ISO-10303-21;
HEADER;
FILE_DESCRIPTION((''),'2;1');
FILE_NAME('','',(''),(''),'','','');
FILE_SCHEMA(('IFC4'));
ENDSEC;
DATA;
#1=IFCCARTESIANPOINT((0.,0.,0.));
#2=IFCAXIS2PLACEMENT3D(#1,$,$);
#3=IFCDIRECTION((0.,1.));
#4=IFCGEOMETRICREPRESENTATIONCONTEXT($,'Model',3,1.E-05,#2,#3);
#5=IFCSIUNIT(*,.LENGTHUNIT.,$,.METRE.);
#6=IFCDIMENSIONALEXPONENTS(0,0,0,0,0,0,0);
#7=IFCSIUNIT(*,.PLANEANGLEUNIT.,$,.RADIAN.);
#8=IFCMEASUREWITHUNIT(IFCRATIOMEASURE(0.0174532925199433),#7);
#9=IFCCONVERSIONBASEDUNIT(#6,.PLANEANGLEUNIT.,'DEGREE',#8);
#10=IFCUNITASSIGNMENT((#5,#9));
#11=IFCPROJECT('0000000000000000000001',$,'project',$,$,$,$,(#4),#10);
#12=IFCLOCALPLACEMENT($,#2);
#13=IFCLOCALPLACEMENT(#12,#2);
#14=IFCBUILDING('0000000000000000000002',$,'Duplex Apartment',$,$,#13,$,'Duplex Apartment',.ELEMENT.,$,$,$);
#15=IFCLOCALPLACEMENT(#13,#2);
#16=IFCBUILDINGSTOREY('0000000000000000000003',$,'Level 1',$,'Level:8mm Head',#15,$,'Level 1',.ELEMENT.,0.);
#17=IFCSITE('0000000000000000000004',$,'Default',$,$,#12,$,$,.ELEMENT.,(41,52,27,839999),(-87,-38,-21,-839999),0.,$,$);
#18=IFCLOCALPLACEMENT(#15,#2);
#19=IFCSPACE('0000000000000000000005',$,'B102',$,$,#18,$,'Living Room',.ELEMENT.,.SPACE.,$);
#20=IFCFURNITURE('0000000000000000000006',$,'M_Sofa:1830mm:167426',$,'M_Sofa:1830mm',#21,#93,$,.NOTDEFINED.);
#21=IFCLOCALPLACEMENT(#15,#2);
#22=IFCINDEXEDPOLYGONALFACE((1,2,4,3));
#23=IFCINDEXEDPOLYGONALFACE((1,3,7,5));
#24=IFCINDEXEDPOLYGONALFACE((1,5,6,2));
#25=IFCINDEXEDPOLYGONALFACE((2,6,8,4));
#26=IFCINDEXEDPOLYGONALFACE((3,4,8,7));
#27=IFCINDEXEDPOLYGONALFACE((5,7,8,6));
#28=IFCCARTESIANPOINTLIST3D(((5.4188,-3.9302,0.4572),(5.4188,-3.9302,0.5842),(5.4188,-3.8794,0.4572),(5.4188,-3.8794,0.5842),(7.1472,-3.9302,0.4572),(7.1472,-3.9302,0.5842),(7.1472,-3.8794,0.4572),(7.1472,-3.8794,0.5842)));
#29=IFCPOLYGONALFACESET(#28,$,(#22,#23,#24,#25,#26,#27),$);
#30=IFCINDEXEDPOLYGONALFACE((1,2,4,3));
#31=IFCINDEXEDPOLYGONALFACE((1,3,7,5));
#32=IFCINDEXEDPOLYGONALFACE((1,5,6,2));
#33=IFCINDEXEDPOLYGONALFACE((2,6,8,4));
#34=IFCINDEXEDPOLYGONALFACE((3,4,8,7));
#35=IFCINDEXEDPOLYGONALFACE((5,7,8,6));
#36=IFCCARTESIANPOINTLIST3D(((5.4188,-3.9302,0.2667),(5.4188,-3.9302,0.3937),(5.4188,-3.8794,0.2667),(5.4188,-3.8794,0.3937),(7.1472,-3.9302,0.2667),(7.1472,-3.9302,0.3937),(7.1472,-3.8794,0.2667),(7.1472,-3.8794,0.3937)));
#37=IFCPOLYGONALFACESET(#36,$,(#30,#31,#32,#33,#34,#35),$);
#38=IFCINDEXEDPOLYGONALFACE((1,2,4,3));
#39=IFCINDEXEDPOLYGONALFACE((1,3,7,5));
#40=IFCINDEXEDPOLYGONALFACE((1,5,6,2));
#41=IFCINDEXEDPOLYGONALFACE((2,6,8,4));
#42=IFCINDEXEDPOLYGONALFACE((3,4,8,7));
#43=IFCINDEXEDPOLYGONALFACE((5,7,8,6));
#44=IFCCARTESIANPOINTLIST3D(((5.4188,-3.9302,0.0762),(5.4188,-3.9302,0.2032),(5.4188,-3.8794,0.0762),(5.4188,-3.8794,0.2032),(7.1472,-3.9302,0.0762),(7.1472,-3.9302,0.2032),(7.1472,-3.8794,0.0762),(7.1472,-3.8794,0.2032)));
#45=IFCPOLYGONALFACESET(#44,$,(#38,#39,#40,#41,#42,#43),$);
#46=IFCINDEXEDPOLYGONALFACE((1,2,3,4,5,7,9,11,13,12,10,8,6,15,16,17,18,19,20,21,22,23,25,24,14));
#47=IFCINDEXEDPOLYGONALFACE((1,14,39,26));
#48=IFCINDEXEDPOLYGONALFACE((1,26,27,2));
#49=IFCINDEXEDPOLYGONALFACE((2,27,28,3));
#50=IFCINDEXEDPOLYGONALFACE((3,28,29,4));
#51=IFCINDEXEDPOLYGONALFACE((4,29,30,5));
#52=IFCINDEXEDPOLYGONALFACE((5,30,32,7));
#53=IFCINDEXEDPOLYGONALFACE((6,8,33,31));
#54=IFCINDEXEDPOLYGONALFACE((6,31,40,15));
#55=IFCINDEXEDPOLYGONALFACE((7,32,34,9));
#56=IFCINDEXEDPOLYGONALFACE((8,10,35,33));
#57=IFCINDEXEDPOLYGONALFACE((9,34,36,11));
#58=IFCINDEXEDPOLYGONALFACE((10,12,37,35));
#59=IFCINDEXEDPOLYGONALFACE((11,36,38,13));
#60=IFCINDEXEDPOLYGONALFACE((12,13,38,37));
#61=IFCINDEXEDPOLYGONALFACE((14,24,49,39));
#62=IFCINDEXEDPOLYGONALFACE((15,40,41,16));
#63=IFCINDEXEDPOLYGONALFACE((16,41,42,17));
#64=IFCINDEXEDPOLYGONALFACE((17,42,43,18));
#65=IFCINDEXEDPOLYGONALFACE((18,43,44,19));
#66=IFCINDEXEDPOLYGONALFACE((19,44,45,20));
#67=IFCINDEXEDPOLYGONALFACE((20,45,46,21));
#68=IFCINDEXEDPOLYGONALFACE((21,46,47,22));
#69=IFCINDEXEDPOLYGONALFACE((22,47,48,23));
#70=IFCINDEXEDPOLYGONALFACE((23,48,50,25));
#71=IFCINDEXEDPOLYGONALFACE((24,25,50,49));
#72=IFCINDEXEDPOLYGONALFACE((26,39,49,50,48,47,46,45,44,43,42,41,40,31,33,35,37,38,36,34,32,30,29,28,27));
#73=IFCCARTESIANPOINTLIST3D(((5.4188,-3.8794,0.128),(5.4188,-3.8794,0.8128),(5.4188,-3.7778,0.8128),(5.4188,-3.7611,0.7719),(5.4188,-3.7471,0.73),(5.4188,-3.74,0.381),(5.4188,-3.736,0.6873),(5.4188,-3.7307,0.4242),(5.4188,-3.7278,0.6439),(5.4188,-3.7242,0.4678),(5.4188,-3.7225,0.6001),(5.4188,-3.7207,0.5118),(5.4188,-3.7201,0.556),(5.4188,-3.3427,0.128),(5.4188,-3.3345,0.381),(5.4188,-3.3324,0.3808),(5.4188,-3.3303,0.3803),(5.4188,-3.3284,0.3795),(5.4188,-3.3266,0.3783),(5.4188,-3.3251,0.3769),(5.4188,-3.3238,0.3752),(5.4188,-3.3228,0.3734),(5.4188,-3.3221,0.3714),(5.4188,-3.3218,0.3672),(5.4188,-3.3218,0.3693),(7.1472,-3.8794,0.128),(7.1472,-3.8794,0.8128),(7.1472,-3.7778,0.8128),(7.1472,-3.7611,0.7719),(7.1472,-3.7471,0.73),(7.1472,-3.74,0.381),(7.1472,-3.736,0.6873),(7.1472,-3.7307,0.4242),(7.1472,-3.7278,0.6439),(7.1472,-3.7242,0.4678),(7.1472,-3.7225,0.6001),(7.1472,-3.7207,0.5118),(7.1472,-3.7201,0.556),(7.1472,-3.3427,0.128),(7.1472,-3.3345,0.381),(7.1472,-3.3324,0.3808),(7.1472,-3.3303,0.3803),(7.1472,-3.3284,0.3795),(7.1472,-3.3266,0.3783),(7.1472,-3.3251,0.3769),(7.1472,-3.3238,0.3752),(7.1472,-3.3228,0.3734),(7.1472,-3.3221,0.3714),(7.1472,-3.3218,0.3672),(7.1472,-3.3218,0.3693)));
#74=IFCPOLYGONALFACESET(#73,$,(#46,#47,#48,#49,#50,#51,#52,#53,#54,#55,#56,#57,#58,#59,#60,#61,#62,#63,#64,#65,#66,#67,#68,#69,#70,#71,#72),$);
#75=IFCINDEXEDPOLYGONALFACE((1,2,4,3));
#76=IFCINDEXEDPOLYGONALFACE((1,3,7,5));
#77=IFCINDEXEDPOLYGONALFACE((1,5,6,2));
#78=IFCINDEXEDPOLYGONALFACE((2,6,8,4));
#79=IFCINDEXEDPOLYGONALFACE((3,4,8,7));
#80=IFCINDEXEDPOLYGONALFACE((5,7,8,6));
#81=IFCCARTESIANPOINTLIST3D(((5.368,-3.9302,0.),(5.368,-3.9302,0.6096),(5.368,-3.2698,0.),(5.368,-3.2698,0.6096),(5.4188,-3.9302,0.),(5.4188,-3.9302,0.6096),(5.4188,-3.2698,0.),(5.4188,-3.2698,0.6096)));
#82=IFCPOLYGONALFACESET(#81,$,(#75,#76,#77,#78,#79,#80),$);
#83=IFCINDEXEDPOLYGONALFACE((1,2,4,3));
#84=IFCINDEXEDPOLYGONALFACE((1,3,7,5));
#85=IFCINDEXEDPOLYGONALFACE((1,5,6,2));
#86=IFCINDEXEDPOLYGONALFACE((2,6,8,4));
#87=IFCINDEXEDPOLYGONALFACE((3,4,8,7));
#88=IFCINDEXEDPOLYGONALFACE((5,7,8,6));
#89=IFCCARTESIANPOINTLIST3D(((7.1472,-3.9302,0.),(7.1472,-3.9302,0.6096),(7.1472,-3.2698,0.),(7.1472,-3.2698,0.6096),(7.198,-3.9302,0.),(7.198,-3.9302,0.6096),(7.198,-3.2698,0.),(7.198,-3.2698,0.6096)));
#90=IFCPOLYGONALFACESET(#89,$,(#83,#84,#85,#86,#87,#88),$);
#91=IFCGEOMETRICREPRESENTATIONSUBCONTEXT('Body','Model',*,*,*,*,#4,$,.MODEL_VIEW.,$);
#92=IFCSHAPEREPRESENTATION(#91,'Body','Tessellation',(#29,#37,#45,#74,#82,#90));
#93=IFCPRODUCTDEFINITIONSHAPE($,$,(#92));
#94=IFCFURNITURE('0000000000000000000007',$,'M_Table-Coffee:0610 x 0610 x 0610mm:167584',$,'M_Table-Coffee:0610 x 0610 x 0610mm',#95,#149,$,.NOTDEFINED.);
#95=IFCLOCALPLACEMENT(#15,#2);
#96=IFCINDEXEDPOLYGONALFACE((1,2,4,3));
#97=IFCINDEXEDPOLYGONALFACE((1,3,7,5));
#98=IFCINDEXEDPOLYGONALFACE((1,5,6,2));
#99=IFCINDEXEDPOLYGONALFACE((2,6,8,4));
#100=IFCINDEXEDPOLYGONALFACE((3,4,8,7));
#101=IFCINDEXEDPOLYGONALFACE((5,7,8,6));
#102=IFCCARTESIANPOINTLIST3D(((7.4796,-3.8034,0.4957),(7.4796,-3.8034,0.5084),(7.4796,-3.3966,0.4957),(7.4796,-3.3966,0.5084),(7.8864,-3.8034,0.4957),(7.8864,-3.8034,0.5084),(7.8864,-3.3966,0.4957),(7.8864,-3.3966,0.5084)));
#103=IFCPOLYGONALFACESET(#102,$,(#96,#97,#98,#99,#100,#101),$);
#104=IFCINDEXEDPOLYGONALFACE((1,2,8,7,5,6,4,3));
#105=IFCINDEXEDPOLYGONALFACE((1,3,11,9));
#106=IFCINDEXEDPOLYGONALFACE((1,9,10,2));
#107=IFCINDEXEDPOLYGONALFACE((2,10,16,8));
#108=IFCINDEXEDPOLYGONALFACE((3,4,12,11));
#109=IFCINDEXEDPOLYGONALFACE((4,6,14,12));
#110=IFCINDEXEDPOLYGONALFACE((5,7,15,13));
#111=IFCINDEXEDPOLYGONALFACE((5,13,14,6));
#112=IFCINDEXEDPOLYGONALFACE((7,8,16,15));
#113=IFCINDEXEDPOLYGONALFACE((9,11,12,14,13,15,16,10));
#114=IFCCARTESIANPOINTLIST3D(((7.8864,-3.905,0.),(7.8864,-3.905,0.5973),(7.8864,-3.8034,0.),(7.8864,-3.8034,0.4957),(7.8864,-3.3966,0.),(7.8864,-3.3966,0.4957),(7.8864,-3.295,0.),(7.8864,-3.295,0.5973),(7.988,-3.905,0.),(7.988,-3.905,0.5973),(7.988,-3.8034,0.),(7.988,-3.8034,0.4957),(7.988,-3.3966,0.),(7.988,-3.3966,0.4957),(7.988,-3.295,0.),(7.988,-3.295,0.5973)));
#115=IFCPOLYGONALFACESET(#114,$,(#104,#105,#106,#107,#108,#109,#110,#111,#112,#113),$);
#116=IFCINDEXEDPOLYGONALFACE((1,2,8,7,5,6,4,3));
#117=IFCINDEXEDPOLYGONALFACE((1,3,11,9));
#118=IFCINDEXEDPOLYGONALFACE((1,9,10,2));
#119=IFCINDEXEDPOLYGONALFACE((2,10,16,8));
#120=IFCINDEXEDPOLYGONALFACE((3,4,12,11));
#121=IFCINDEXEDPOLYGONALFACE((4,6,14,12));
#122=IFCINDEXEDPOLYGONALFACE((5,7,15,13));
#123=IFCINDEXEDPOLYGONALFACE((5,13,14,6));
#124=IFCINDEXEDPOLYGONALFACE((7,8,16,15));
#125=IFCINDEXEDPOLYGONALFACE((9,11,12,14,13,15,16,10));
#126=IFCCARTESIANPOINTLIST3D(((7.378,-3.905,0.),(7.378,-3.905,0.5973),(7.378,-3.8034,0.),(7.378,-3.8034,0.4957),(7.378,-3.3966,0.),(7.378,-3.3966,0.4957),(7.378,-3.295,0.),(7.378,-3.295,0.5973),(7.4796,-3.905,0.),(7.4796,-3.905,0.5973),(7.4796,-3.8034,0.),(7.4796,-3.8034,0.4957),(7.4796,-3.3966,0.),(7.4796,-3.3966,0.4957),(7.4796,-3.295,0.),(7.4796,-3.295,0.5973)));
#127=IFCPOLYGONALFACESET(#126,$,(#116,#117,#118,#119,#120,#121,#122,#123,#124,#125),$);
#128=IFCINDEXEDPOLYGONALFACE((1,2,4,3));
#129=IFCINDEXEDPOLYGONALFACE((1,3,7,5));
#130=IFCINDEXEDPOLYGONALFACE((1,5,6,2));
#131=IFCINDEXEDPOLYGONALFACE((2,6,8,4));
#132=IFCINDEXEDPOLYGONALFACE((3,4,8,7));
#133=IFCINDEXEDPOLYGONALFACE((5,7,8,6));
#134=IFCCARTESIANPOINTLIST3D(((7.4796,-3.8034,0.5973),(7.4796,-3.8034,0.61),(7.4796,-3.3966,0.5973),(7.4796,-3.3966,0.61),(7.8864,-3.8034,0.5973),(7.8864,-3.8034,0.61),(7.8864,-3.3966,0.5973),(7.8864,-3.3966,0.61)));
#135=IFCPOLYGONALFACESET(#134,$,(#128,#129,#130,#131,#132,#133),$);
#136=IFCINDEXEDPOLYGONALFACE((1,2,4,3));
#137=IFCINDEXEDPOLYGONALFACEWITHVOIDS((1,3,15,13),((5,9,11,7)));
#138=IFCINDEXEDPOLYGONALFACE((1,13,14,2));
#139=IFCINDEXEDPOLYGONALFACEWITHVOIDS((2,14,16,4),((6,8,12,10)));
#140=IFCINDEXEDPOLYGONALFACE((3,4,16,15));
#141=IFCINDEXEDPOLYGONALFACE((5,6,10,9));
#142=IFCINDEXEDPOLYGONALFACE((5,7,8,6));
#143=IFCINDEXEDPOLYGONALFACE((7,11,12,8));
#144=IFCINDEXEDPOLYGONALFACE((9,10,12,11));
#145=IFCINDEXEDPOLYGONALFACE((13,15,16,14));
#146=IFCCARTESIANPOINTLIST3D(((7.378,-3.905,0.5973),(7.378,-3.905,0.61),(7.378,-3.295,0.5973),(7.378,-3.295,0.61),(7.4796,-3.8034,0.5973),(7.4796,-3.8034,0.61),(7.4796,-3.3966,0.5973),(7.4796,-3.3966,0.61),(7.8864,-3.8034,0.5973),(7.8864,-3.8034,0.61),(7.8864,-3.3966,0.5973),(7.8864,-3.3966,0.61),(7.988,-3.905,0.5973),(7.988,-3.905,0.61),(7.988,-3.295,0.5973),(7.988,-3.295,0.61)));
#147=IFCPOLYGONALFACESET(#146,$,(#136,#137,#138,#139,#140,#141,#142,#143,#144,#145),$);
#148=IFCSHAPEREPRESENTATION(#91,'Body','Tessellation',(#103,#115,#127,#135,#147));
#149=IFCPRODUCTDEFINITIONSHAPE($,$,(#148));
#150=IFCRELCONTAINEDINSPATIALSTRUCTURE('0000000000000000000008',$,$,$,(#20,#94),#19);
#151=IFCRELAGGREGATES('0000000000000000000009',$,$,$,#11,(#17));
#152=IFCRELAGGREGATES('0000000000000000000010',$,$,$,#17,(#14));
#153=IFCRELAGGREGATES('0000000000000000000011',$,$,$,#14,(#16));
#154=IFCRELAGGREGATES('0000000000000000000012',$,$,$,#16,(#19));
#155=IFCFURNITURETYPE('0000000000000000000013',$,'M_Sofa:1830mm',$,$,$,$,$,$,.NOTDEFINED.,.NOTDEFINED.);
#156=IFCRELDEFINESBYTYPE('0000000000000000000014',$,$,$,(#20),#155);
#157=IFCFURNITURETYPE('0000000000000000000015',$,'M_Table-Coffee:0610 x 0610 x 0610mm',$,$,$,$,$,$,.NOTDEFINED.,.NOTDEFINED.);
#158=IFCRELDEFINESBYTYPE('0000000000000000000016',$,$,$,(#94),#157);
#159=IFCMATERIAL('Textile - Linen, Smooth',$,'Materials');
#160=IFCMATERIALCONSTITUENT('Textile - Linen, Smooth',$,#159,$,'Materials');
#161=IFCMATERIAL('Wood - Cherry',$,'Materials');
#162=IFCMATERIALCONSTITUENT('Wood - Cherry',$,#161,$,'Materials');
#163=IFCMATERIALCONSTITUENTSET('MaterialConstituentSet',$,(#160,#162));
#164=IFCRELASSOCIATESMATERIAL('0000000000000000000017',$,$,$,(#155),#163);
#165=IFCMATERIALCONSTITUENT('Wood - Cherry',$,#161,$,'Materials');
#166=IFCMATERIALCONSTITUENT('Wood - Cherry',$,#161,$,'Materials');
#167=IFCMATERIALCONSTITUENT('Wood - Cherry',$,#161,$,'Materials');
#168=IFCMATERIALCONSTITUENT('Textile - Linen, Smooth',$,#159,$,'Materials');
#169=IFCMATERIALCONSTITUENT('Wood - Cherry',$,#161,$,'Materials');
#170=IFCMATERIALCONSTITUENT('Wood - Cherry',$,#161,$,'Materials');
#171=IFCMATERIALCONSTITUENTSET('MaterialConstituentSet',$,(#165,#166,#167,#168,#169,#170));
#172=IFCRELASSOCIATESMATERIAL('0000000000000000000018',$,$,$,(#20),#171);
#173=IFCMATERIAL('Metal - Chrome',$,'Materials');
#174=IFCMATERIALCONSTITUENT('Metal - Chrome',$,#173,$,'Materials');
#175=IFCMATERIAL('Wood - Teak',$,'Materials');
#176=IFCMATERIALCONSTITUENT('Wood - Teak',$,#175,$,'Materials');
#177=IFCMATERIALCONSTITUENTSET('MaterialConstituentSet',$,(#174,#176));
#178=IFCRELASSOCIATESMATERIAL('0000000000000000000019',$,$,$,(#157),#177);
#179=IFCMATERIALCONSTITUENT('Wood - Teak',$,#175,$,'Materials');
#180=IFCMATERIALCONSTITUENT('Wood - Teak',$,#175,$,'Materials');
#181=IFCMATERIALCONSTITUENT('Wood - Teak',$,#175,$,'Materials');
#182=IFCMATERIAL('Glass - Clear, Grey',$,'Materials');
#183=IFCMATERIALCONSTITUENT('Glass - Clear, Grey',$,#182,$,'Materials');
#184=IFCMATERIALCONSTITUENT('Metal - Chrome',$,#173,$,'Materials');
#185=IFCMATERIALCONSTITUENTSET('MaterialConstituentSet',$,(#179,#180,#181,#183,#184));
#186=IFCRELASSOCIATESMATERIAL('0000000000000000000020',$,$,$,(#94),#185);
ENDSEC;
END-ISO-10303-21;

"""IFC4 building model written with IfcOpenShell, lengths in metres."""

from ifc_helpers import new_model, entity, si_unit, converted_unit, direction, frame, origin, place, context, subcontext, project, spatial, indexed_curve, outline, extrude, source, transform, mapped, material, constituent, constituent_set, type_object, type_shapes, element, save


model = new_model("IFC4")

# Units and contexts
model_context = context("Model", 3, precision=1e-05, world=origin(), true_north=direction((0.0, 1.0)))
body_context = subcontext(model_context, "Body", "Model", "MODEL_VIEW")
ifc_project = project(units=[si_unit("LENGTHUNIT", "METRE"), converted_unit("PLANEANGLEUNIT", "DEGREE", entity("IfcRatioMeasure", 0.0174532925199433), si_unit("PLANEANGLEUNIT", "RADIAN"), dimensions=[0, 0, 0, 0, 0, 0, 0])], contexts=[model_context])

# Site, building, storey
site_placement = place(None, origin())
site = spatial("IfcSite", under=ifc_project, at=site_placement, Name="Default", CompositionType="ELEMENT", RefLatitude=(41, 52, 27, 839999), RefLongitude=(-87, -38, -21, -839999), RefElevation=0.0)
building_placement = place(site_placement, origin())
building = spatial("IfcBuilding", under=site, at=building_placement, Name="Duplex Apartment", LongName="Duplex Apartment", CompositionType="ELEMENT")
storey_placement = place(building_placement, origin())
storey = spatial("IfcBuildingStorey", under=building, at=storey_placement, Name="Level 1", ObjectType="Level:8mm Head", LongName="Level 1", CompositionType="ELEMENT", Elevation=0.0)

# Shared definitions
space_1_placement = place(storey_placement, origin())
space_1 = spatial("IfcSpace", under=storey, at=space_1_placement, Name="B102", LongName="Living Room", CompositionType="ELEMENT", PredefinedType="SPACE")

# Furniture
ifc_material_1 = material(Name="Wood - Cherry", Category="Materials")
ifc_constituent_1 = constituent(ifc_material_1, Name="Wood - Cherry", Category="Materials")
ifc_constituent_2 = constituent(ifc_material_1, Name="Wood - Cherry", Category="Materials")
ifc_constituent_3 = constituent(ifc_material_1, Name="Wood - Cherry", Category="Materials")
ifc_material_2 = material(Name="Textile - Linen, Smooth", Category="Materials")
ifc_constituent_4 = constituent(ifc_material_2, Name="Textile - Linen, Smooth", Category="Materials")
ifc_constituent_5 = constituent(ifc_material_1, Name="Wood - Cherry", Category="Materials")
ifc_constituent_6 = constituent(ifc_material_1, Name="Wood - Cherry", Category="Materials")
ifc_constituent_set_1 = constituent_set(constituents=[ifc_constituent_1, ifc_constituent_2, ifc_constituent_3, ifc_constituent_4, ifc_constituent_5, ifc_constituent_6], Name="MaterialConstituentSet")
ifc_constituent_7 = constituent(ifc_material_2, Name="Textile - Linen, Smooth", Category="Materials")
ifc_constituent_8 = constituent(ifc_material_1, Name="Wood - Cherry", Category="Materials")
ifc_constituent_set_2 = constituent_set(constituents=[ifc_constituent_7, ifc_constituent_8], Name="MaterialConstituentSet")
furniture_type_1 = type_object("IfcFurnitureType", Name="M_Sofa:1830mm", AssemblyPlace="NOTDEFINED", PredefinedType="NOTDEFINED", material=ifc_constituent_set_2)
shared_shape_1 = source(origin(), body_context, "Body", "SweptSolid", [
    extrude(outline(indexed_curve([(-0.8642, -0.0254), (0.8642, -0.0254), (0.8642, 0.0254), (-0.8642, 0.0254), (-0.8642, -0.0254)], self_intersect=False)), frame((0.0704, 0.451, 0.4572)), (0.0, 0.0, 1.0), 0.127),
    extrude(outline(indexed_curve([(-0.8642, -0.0254), (0.8642, -0.0254), (0.8642, 0.0254), (-0.8642, 0.0254), (-0.8642, -0.0254)], self_intersect=False)), frame((0.0704, 0.451, 0.2667)), (0.0, 0.0, 1.0), 0.127),
    extrude(outline(indexed_curve([(-0.8642, -0.0254), (0.8642, -0.0254), (0.8642, 0.0254), (-0.8642, 0.0254), (-0.8642, -0.0254)], self_intersect=False)), frame((0.0704, 0.451, 0.0762)), (0.0, 0.0, 1.0), 0.127),
    extrude(outline(indexed_curve([(-0.1292, 0.0491), (0.2763, 0.0491), (0.2784, 0.0493), (0.2805, 0.0498), (0.2824, 0.0506), (0.2842, 0.0518), (0.2857, 0.0532), (0.287, 0.0549), (0.288, 0.0567), (0.2887, 0.0587), (0.289, 0.0608), (0.289, 0.0629), (0.2681, 0.3021), (-0.2686, 0.3021), (-0.2686, -0.3827), (-0.167, -0.3827), (-0.1503, -0.3418), (-0.1363, -0.2999), (-0.1252, -0.2572), (-0.117, -0.2138), (-0.1117, -0.17), (-0.1093, -0.1259), (-0.1099, -0.0817), (-0.1134, -0.0377), (-0.1199, 0.006), (-0.1292, 0.0491)], self_intersect=False)), frame((-0.7938, 0.157, 0.4301), z_axis=(1.0, 0.0, 0.0), x_axis=(0.0, -1.0, 0.0)), (0.0, 0.0, 1.0), 1.7284),
    extrude(outline(indexed_curve([(-0.0254, -0.3302), (0.0254, -0.3302), (0.0254, 0.3302), (-0.0254, 0.3302), (-0.0254, -0.3302)], self_intersect=False)), frame((0.96, 0.1462, 0.0), z_axis=(0.0, 0.0, 1.0), x_axis=(-1.0, 0.0, 0.0)), (0.0, 0.0, 1.0), 0.6096),
    extrude(outline(indexed_curve([(-0.0254, -0.3302), (0.0254, -0.3302), (0.0254, 0.3302), (-0.0254, 0.3302), (-0.0254, -0.3302)], self_intersect=False)), frame((-0.8192, 0.1462, 0.0), z_axis=(0.0, 0.0, 1.0), x_axis=(-1.0, 0.0, 0.0)), (0.0, 0.0, 1.0), 0.6096),
])
type_shapes(furniture_type_1, [shared_shape_1])
furniture_1_placement = place(space_1_placement, frame((6.3534, -3.4538, 0.0), z_axis=(0.0, 0.0, 1.0), x_axis=(-1.0, 0.0, 0.0)))
element("IfcFurniture", 1, at=furniture_1_placement, inside=space_1, type_object=furniture_type_1, material=ifc_constituent_set_1, Name="M_Sofa:1830mm:167426", ObjectType="M_Sofa:1830mm", PredefinedType="NOTDEFINED", context=body_context, shape_type="MappedRepresentation", body=[
    mapped(shared_shape_1, transform((0.0, 0.0, 0.0), scale=1.0)),
])
ifc_material_3 = material(Name="Wood - Teak", Category="Materials")
ifc_constituent_9 = constituent(ifc_material_3, Name="Wood - Teak", Category="Materials")
ifc_constituent_10 = constituent(ifc_material_3, Name="Wood - Teak", Category="Materials")
ifc_constituent_11 = constituent(ifc_material_3, Name="Wood - Teak", Category="Materials")
ifc_material_4 = material(Name="Glass - Clear, Grey", Category="Materials")
ifc_constituent_12 = constituent(ifc_material_4, Name="Glass - Clear, Grey", Category="Materials")
ifc_material_5 = material(Name="Metal - Chrome", Category="Materials")
ifc_constituent_13 = constituent(ifc_material_5, Name="Metal - Chrome", Category="Materials")
ifc_constituent_set_3 = constituent_set(constituents=[ifc_constituent_9, ifc_constituent_10, ifc_constituent_11, ifc_constituent_12, ifc_constituent_13], Name="MaterialConstituentSet")
ifc_constituent_14 = constituent(ifc_material_5, Name="Metal - Chrome", Category="Materials")
ifc_constituent_15 = constituent(ifc_material_3, Name="Wood - Teak", Category="Materials")
ifc_constituent_set_4 = constituent_set(constituents=[ifc_constituent_14, ifc_constituent_15], Name="MaterialConstituentSet")
furniture_type_2 = type_object("IfcFurnitureType", Name="M_Table-Coffee:0610 x 0610 x 0610mm", AssemblyPlace="NOTDEFINED", PredefinedType="NOTDEFINED", material=ifc_constituent_set_4)
shared_shape_2 = source(origin(), body_context, "Body", "SweptSolid", [
    extrude(outline(indexed_curve([(-0.2034, -0.2034), (0.2034, -0.2034), (0.2034, 0.2034), (-0.2034, 0.2034), (-0.2034, -0.2034)], self_intersect=False)), frame((0.0183, 0.0952, 0.4957), z_axis=(0.0, 0.0, 1.0), x_axis=(-1.0, 0.0, 0.0)), (0.0, 0.0, 1.0), 0.0127),
    extrude(outline(indexed_curve([(-0.2732, -0.305), (0.324, -0.305), (0.324, 0.305), (-0.2732, 0.305), (-0.2732, 0.2034), (0.2225, 0.2034), (0.2225, -0.2034), (-0.2732, -0.2034), (-0.2732, -0.305)], self_intersect=False)), frame((0.2217, 0.0952, 0.2732), z_axis=(1.0, 0.0, 0.0), x_axis=(0.0, 0.0, 1.0)), (0.0, 0.0, 1.0), 0.1016),
    extrude(outline(indexed_curve([(-0.305, -0.3241), (0.305, -0.3241), (0.305, 0.2733), (0.2034, 0.2733), (0.2034, -0.2224), (-0.2034, -0.2224), (-0.2034, 0.2733), (-0.305, 0.2733), (-0.305, -0.3241)], self_intersect=False)), frame((-0.2867, 0.0952, 0.2733), z_axis=(1.0, 0.0, 0.0), x_axis=(0.0, -1.0, 0.0)), (0.0, 0.0, 1.0), 0.1016),
    extrude(outline(indexed_curve([(-0.2034, -0.2034), (0.2034, -0.2034), (0.2034, 0.2034), (-0.2034, 0.2034), (-0.2034, -0.2034)], self_intersect=False)), frame((0.0183, 0.0952, 0.5973), z_axis=(0.0, 0.0, 1.0), x_axis=(-1.0, 0.0, 0.0)), (0.0, 0.0, 1.0), 0.0127),
    extrude(outline(indexed_curve([(-0.305, -0.305), (0.305, -0.305), (0.305, 0.305), (-0.305, 0.305), (-0.305, -0.305)], self_intersect=False), holes=[indexed_curve([(-0.2034, -0.2034), (-0.2034, 0.2034), (0.2034, 0.2034), (0.2034, -0.2034), (-0.2034, -0.2034)], self_intersect=False)]), frame((0.0183, 0.0952, 0.5973), z_axis=(0.0, 0.0, 1.0), x_axis=(-1.0, 0.0, 0.0)), (0.0, 0.0, 1.0), 0.0127),
])
type_shapes(furniture_type_2, [shared_shape_2])
furniture_2_placement = place(space_1_placement, frame((7.6647, -3.6952, 0.0)))
element("IfcFurniture", 2, at=furniture_2_placement, inside=space_1, type_object=furniture_type_2, material=ifc_constituent_set_3, Name="M_Table-Coffee:0610 x 0610 x 0610mm:167584", ObjectType="M_Table-Coffee:0610 x 0610 x 0610mm", PredefinedType="NOTDEFINED", context=body_context, shape_type="MappedRepresentation", body=[
    mapped(shared_shape_2, transform((0.0, 0.0, 0.0), scale=1.0)),
])

save(model, "model.ifc")
